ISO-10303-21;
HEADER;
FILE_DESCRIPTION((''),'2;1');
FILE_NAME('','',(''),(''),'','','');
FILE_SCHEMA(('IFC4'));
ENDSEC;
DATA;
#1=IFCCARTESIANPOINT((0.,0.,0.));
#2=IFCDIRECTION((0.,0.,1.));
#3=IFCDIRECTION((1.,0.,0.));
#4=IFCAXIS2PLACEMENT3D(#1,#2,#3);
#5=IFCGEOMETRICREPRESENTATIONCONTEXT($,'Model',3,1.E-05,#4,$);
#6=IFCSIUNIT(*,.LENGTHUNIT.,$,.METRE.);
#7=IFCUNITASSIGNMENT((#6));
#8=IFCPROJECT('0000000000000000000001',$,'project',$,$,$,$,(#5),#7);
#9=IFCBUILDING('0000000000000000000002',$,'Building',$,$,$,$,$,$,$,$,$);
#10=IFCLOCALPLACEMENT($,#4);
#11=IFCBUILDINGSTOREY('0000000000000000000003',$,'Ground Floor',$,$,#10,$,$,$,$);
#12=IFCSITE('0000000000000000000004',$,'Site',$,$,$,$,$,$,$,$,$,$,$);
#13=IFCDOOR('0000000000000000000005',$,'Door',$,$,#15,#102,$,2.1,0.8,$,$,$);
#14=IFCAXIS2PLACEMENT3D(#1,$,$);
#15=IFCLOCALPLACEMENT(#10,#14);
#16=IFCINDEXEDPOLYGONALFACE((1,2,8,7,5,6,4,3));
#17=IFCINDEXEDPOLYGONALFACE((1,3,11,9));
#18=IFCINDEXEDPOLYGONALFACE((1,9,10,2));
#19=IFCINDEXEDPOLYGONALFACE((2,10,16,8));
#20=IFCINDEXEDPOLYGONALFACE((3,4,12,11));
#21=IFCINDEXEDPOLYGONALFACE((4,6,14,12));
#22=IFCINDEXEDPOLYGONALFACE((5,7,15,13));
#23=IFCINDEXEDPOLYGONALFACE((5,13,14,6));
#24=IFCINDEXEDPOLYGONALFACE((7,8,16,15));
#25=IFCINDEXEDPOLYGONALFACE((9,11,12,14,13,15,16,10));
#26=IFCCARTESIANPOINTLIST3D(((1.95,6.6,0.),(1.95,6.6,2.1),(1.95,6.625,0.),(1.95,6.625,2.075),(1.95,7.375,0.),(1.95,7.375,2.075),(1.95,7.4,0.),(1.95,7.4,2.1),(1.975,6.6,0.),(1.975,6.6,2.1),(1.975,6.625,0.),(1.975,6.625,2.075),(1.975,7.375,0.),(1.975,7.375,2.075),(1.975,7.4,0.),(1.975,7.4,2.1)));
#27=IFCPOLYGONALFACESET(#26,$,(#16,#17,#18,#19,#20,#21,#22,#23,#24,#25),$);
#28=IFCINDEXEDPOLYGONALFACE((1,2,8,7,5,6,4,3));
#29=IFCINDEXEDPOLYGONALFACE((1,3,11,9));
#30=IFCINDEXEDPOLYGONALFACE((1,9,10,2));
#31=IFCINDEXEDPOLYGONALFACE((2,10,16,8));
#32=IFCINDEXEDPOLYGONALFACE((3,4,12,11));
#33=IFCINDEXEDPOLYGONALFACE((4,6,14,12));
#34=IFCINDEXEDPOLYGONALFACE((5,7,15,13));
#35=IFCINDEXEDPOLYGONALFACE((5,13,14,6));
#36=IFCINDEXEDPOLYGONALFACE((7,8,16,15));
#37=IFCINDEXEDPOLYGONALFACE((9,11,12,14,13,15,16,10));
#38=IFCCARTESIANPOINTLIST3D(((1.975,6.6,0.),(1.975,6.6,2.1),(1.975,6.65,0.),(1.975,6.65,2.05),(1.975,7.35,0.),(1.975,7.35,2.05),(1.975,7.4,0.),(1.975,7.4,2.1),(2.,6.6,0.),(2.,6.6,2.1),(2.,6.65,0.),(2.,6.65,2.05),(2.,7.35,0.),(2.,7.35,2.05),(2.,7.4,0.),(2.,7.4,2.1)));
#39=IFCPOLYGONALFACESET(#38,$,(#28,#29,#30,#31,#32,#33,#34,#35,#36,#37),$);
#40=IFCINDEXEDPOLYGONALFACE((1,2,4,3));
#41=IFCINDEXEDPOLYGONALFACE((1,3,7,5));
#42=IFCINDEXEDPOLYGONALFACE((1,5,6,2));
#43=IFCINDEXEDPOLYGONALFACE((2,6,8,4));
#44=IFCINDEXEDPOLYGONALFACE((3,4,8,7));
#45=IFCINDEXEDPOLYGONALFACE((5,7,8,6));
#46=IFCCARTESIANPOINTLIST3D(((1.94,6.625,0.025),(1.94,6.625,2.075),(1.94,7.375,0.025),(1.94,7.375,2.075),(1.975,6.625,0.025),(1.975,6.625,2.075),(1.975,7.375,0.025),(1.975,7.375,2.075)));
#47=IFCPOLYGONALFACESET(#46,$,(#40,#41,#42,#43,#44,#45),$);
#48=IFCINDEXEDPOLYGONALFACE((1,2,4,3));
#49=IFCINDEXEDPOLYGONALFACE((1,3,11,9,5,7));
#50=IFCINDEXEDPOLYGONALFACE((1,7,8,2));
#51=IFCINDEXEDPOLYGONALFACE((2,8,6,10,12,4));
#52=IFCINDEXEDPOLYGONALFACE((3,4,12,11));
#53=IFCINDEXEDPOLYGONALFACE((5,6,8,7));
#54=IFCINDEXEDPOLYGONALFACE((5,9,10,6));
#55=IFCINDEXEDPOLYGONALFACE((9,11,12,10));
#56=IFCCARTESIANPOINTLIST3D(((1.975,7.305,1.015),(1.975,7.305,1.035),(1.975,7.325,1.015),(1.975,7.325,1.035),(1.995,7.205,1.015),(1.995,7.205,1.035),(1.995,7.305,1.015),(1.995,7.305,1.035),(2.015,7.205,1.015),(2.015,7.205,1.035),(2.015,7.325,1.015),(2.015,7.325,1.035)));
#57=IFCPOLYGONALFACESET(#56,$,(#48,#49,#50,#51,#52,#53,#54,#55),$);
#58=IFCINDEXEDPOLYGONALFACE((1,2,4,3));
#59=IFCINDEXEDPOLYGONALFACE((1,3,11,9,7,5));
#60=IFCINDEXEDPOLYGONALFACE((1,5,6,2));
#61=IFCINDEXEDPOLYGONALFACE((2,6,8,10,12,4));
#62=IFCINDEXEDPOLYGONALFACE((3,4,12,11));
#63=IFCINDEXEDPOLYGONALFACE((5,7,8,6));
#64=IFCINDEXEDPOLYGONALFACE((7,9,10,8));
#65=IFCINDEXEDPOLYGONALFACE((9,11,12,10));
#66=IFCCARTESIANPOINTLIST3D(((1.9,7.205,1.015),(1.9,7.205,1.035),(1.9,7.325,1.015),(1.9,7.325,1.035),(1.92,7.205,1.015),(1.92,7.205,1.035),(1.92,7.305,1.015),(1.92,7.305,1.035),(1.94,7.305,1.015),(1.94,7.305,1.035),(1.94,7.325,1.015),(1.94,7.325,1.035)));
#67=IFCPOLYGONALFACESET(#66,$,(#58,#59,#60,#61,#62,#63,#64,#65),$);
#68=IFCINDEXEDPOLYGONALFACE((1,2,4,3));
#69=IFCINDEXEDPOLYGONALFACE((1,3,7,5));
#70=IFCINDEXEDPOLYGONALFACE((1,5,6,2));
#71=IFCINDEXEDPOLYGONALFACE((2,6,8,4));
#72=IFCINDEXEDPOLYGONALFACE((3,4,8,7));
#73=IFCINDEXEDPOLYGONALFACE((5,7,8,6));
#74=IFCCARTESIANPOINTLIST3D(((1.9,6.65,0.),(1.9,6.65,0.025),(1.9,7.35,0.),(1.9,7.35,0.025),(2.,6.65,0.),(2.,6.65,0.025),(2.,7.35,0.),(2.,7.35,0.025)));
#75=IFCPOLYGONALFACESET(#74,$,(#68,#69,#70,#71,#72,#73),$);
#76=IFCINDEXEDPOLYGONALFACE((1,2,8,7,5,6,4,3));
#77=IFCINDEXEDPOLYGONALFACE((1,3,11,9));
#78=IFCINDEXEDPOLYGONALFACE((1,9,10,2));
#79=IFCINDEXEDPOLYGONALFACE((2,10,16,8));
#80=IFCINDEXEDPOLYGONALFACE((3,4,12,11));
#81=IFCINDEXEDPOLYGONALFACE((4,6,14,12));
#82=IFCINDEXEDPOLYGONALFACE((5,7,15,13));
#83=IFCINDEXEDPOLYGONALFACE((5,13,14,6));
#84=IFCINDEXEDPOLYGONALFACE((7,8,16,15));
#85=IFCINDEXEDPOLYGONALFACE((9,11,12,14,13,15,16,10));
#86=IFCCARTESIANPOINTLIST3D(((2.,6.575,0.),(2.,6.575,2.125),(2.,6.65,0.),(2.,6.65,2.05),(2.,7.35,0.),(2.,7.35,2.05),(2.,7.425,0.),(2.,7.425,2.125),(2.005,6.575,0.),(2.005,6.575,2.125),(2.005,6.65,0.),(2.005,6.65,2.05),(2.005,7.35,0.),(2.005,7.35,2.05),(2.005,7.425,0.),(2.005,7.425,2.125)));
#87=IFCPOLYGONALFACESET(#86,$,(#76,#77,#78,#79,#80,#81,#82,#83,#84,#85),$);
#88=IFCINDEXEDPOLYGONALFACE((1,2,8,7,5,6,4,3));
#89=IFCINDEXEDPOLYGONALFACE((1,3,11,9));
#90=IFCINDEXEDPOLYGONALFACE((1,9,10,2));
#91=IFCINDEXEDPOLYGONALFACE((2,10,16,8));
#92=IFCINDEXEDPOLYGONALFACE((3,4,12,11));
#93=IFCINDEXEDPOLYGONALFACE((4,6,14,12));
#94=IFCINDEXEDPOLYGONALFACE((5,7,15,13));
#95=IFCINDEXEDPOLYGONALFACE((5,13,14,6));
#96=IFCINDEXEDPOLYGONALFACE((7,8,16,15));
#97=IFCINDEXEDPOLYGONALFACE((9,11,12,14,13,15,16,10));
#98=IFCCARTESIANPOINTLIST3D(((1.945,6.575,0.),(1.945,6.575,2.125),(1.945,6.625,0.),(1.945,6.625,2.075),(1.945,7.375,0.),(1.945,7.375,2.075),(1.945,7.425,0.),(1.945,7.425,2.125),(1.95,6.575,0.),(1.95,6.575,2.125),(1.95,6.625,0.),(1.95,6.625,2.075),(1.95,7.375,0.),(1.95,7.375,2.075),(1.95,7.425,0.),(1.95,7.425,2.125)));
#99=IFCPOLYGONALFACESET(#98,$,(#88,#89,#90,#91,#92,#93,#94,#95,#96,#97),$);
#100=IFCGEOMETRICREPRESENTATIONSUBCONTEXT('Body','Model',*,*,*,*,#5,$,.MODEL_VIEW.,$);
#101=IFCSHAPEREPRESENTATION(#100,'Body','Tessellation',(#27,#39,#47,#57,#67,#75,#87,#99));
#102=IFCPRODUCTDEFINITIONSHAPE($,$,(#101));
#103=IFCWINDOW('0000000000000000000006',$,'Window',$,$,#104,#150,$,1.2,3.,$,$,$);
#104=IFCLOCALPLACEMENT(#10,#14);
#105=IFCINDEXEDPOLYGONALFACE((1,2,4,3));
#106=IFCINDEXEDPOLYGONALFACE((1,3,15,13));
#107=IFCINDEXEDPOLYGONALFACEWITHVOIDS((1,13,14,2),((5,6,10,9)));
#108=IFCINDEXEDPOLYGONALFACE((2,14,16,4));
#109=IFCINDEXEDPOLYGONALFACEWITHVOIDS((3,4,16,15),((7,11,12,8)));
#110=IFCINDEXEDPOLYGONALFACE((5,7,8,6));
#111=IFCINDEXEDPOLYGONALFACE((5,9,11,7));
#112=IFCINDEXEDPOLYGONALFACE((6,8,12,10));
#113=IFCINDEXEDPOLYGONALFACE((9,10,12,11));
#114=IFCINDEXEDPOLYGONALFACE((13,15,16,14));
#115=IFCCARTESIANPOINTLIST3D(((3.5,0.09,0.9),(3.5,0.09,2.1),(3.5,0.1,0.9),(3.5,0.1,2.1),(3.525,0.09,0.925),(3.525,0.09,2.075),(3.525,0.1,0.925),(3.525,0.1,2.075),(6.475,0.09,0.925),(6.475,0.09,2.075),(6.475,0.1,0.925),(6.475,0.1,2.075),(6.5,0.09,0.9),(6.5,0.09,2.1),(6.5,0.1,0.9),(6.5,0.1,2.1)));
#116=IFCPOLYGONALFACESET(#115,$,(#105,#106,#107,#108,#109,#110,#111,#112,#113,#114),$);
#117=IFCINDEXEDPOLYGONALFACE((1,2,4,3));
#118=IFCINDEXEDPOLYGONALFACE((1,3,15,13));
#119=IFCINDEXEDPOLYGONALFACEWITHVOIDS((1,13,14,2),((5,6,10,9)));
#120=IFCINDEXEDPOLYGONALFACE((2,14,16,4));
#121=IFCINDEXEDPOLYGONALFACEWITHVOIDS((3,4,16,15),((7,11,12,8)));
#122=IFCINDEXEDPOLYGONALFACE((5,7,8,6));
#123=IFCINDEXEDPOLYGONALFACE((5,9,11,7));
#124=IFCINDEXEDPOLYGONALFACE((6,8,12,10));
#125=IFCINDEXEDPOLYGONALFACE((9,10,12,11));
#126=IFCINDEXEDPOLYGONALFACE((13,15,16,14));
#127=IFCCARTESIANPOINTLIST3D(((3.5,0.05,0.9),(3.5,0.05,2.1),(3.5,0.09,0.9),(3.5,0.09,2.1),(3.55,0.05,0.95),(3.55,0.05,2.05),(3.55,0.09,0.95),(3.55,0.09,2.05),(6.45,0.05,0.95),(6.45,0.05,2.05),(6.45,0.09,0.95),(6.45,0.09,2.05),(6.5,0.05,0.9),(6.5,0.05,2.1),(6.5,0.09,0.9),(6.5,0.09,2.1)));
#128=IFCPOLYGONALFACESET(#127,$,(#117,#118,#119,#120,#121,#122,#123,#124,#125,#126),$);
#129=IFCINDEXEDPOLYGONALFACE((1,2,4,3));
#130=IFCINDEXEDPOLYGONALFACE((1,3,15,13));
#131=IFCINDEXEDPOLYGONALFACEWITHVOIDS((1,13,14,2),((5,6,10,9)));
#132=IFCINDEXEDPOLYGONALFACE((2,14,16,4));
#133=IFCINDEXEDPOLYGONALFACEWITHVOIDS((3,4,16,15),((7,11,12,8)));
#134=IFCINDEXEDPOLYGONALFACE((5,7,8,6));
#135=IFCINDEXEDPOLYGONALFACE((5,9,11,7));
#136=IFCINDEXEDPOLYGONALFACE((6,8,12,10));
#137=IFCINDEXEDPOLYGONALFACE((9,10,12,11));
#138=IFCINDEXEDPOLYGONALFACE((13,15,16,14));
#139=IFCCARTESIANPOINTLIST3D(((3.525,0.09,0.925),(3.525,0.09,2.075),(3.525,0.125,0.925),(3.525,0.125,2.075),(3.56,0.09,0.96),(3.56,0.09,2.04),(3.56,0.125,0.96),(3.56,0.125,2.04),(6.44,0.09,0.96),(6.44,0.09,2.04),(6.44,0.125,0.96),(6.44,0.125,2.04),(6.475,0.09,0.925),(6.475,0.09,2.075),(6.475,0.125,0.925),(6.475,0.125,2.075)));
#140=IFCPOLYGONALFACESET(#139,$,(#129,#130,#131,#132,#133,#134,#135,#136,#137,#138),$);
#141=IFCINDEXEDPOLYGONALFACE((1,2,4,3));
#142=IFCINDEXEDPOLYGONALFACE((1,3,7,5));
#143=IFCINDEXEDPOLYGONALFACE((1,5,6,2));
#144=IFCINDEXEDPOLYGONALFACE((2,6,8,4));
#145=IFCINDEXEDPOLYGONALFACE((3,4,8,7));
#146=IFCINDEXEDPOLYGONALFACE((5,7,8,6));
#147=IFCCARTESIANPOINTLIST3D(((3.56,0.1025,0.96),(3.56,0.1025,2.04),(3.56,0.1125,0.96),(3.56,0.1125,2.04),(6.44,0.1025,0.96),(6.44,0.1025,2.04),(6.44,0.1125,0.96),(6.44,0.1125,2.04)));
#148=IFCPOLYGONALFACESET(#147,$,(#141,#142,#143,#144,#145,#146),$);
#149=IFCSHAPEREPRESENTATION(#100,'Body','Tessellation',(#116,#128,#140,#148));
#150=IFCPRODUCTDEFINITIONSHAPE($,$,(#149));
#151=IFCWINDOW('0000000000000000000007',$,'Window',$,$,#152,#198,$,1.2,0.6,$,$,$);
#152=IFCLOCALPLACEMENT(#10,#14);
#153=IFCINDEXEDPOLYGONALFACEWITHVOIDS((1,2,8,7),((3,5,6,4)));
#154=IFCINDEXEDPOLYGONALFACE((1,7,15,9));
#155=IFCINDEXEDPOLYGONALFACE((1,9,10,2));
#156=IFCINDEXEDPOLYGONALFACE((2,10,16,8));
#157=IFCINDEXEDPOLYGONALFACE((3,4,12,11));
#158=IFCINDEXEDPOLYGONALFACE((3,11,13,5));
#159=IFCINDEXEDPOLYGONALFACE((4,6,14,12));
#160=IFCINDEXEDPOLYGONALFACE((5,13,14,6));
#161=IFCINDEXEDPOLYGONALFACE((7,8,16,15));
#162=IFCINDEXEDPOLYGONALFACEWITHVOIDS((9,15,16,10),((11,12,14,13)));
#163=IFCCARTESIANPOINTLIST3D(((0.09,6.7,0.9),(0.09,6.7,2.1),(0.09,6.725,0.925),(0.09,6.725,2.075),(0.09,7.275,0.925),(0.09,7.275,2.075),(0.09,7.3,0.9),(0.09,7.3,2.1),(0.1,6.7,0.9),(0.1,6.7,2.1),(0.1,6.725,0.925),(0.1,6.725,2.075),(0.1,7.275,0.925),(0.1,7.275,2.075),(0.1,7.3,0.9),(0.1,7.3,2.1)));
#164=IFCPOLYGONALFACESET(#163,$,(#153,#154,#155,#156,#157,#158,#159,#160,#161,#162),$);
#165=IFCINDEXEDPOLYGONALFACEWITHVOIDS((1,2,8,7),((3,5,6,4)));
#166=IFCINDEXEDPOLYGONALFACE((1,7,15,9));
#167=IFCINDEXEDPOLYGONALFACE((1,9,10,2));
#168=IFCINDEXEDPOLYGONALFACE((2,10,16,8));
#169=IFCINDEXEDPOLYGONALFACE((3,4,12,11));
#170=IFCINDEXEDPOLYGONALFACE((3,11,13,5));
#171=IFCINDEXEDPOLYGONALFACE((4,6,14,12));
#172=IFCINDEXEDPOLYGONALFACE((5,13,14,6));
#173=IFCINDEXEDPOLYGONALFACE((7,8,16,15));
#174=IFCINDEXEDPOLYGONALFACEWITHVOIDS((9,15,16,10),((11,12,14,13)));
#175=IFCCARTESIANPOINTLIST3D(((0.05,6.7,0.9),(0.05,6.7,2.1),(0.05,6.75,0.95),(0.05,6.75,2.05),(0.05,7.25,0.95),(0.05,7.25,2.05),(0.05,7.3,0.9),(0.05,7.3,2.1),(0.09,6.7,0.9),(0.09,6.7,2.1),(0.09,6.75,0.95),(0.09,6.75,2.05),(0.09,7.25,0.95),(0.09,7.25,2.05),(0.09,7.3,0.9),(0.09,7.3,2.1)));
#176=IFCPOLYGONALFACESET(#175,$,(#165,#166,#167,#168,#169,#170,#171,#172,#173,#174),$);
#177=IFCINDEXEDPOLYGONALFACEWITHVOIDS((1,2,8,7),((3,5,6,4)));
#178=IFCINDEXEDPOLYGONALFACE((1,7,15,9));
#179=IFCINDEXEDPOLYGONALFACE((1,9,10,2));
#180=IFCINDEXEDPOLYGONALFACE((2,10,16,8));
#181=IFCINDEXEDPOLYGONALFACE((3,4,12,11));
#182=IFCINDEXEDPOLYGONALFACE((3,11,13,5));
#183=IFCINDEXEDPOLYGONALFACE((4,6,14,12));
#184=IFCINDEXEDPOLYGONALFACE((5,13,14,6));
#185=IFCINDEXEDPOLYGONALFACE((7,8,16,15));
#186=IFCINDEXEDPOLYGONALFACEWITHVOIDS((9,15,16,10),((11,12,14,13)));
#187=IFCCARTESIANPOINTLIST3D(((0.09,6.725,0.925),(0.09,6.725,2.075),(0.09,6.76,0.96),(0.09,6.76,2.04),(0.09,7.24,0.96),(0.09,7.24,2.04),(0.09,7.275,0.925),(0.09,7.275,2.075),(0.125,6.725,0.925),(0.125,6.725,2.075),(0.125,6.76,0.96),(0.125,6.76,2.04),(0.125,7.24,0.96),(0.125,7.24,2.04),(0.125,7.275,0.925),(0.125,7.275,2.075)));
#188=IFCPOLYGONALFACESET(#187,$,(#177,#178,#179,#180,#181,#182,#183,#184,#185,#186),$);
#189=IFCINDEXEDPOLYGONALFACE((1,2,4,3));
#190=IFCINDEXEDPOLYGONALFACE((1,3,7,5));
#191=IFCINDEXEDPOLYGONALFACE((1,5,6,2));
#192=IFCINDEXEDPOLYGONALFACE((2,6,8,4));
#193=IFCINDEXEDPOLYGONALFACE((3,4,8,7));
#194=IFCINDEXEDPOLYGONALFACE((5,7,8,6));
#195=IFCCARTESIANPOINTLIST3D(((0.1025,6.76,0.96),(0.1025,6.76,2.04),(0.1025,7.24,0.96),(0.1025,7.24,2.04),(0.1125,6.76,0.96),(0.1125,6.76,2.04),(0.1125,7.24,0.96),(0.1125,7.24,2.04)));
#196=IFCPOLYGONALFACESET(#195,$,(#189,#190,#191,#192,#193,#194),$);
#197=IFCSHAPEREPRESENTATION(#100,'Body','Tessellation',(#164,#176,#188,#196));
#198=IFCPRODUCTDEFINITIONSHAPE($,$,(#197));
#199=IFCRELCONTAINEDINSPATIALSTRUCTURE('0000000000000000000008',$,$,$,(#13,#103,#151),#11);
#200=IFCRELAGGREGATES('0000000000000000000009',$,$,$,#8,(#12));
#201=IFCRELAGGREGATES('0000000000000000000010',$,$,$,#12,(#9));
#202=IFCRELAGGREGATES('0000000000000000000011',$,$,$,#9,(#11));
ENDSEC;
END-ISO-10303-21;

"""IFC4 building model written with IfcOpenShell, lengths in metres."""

from ifc_helpers import new_model, si_unit, frame, origin_with_axes, place, context, subcontext, project, spatial, line, indexed_curve, outline, extrude, element, save


model = new_model("IFC4")

# Units and contexts
model_context = context("Model", 3, precision=1e-05, world=origin_with_axes())
body_context = subcontext(model_context, "Body", "Model", "MODEL_VIEW")
ifc_project = project(units=[si_unit("LENGTHUNIT", "METRE")], contexts=[model_context])

# Site, building, storey
site = spatial("IfcSite", under=ifc_project, Name="Site")
building = spatial("IfcBuilding", under=site, Name="Building")
storey_placement = place(None, origin_with_axes())
storey = spatial("IfcBuildingStorey", under=building, at=storey_placement, Name="Ground Floor")

# Door
door_1_placement = place(storey_placement, frame((2.0, 6.6, 0.0), z_axis=(0.0, 0.0, 1.0), x_axis=(0.0, 1.0, 0.0)))
element("IfcDoor", 1, at=door_1_placement, inside=storey, Name="Door", OverallHeight=2.1, OverallWidth=0.8, context=body_context, shape_type="SweptSolid", body=[
    extrude(outline(indexed_curve([(0.0, 0.0), (0.0, 2.1), (0.8, 2.1), (0.8, 0.0), (0.775, 0.0), (0.775, 2.075), (0.025, 2.075), (0.025, 0.0)], segments=[line(1, 2, 3, 4, 5, 6, 7, 8, 1)])), frame((0.0, 0.025, 0.0), z_axis=(0.0, -1.0, 0.0), x_axis=(1.0, 0.0, 0.0)), (0.0, 0.0, -1.0), 0.025),
    extrude(outline(indexed_curve([(0.0, 0.0), (0.0, 2.1), (0.8, 2.1), (0.8, 0.0), (0.75, 0.0), (0.75, 2.05), (0.05, 2.05), (0.05, 0.0)], segments=[line(1, 2, 3, 4, 5, 6, 7, 8, 1)])), frame((0.0, 0.0, 0.0), z_axis=(0.0, -1.0, 0.0), x_axis=(1.0, 0.0, 0.0)), (0.0, 0.0, -1.0), 0.025),
    extrude(outline(indexed_curve([(0.0, 0.0), (0.75, 0.0), (0.75, 0.035), (0.0, 0.035)], segments=[line(1, 2, 3, 4, 1)])), frame((0.025, 0.025, 0.025), z_axis=(0.0, 0.0, 1.0), x_axis=(1.0, 0.0, 0.0)), (0.0, 0.0, 1.0), 2.05),
    extrude(outline(indexed_curve([(0.0, 0.0), (0.0, -0.04), (-0.12, -0.04), (-0.12, -0.02), (-0.02, -0.02), (-0.02, 0.0)], segments=[line(1, 2, 3, 4, 5, 6, 1)])), frame((0.725, 0.025, 1.015), z_axis=(0.0, 0.0, 1.0), x_axis=(1.0, 0.0, 0.0)), (0.0, 0.0, 1.0), 0.02),
    extrude(outline(indexed_curve([(0.0, 0.0), (0.0, 0.04), (-0.12, 0.04), (-0.12, 0.02), (-0.02, 0.02), (-0.02, 0.0)], segments=[line(1, 2, 3, 4, 5, 6, 1)])), frame((0.725, 0.06, 1.015), z_axis=(0.0, 0.0, 1.0), x_axis=(1.0, 0.0, 0.0)), (0.0, 0.0, 1.0), 0.02),
    extrude(outline(indexed_curve([(0.0, 0.0), (0.7, 0.0), (0.7, 0.1), (0.0, 0.1)], segments=[line(1, 2, 3, 4, 1)])), frame((0.05, 0.0, 0.0), z_axis=(0.0, 0.0, 1.0), x_axis=(1.0, 0.0, 0.0)), (0.0, 0.0, 1.0), 0.025),
    extrude(outline(indexed_curve([(0.0, 0.0), (0.0, 2.125), (0.85, 2.125), (0.85, 0.0), (0.775, 0.0), (0.775, 2.05), (0.075, 2.05), (0.075, 0.0)], segments=[line(1, 2, 3, 4, 5, 6, 7, 8, 1)])), frame((-0.025, -0.005, 0.0), z_axis=(0.0, -1.0, 0.0), x_axis=(1.0, 0.0, 0.0)), (0.0, 0.0, -1.0), 0.005),
    extrude(outline(indexed_curve([(0.0, 0.0), (0.0, 2.125), (0.85, 2.125), (0.85, 0.0), (0.8, 0.0), (0.8, 2.075), (0.05, 2.075), (0.05, 0.0)], segments=[line(1, 2, 3, 4, 5, 6, 7, 8, 1)])), frame((-0.025, 0.05, 0.0), z_axis=(0.0, -1.0, 0.0), x_axis=(1.0, 0.0, 0.0)), (0.0, 0.0, -1.0), 0.005),
])

# Windows
window_placement = place(storey_placement, frame((3.5, 0.0, 0.9), z_axis=(0.0, 0.0, 1.0), x_axis=(1.0, 0.0, 0.0)))
element("IfcWindow", 2, at=window_placement, inside=storey, Name="Window", OverallHeight=1.2, OverallWidth=3.0, context=body_context, shape_type="SweptSolid", body=[
    extrude(outline(indexed_curve([(0.0, 0.0), (3.0, 0.0), (3.0, 1.2), (0.0, 1.2)], segments=[line(1, 2, 3, 4, 1)]), holes=[indexed_curve([(0.025, 0.025), (2.975, 0.025), (2.975, 1.175), (0.025, 1.175)], segments=[line(1, 2, 3, 4, 1)])]), frame((0.0, 0.09, 0.0), z_axis=(0.0, -1.0, 0.0), x_axis=(1.0, 0.0, 0.0)), (0.0, 0.0, -1.0), 0.01),
    extrude(outline(indexed_curve([(0.0, 0.0), (3.0, 0.0), (3.0, 1.2), (0.0, 1.2)], segments=[line(1, 2, 3, 4, 1)]), holes=[indexed_curve([(0.05, 0.05), (2.95, 0.05), (2.95, 1.15), (0.05, 1.15)], segments=[line(1, 2, 3, 4, 1)])]), frame((0.0, 0.05, 0.0), z_axis=(0.0, -1.0, 0.0), x_axis=(1.0, 0.0, 0.0)), (0.0, 0.0, -1.0), 0.04),
    extrude(outline(indexed_curve([(0.0, 0.0), (2.95, 0.0), (2.95, 1.15), (0.0, 1.15)], segments=[line(1, 2, 3, 4, 1)]), holes=[indexed_curve([(0.035, 0.035), (2.915, 0.035), (2.915, 1.115), (0.035, 1.115)], segments=[line(1, 2, 3, 4, 1)])]), frame((0.025, 0.09, 0.025), z_axis=(0.0, -1.0, 0.0), x_axis=(1.0, 0.0, 0.0)), (0.0, 0.0, -1.0), 0.035),
    extrude(outline(indexed_curve([(0.035, 0.035), (2.915, 0.035), (2.915, 1.115), (0.035, 1.115)], segments=[line(1, 2, 3, 4, 1)])), frame((0.025, 0.1025, 0.025), z_axis=(0.0, -1.0, 0.0), x_axis=(1.0, 0.0, 0.0)), (0.0, 0.0, -1.0), 0.01),
])
for number, where, z_axis, x_axis, name in (
    (3, (0.0, 7.3, 0.9), (0.0, 0.0, 1.0), (0.0, -1.0, 0.0), "Window"),
):
    element("IfcWindow", number, at=place(storey_placement, frame(where, z_axis=z_axis, x_axis=x_axis)), inside=storey, Name=name, OverallHeight=1.2, OverallWidth=0.6, context=body_context, shape_type="SweptSolid", body=[
        extrude(outline(indexed_curve([(0.0, 0.0), (0.6, 0.0), (0.6, 1.2), (0.0, 1.2)], segments=[line(1, 2, 3, 4, 1)]), holes=[indexed_curve([(0.025, 0.025), (0.575, 0.025), (0.575, 1.175), (0.025, 1.175)], segments=[line(1, 2, 3, 4, 1)])]), frame((0.0, 0.09, 0.0), z_axis=(0.0, -1.0, 0.0), x_axis=(1.0, 0.0, 0.0)), (0.0, 0.0, -1.0), 0.01),
        extrude(outline(indexed_curve([(0.0, 0.0), (0.6, 0.0), (0.6, 1.2), (0.0, 1.2)], segments=[line(1, 2, 3, 4, 1)]), holes=[indexed_curve([(0.05, 0.05), (0.55, 0.05), (0.55, 1.15), (0.05, 1.15)], segments=[line(1, 2, 3, 4, 1)])]), frame((0.0, 0.05, 0.0), z_axis=(0.0, -1.0, 0.0), x_axis=(1.0, 0.0, 0.0)), (0.0, 0.0, -1.0), 0.04),
        extrude(outline(indexed_curve([(0.0, 0.0), (0.55, 0.0), (0.55, 1.15), (0.0, 1.15)], segments=[line(1, 2, 3, 4, 1)]), holes=[indexed_curve([(0.035, 0.035), (0.515, 0.035), (0.515, 1.115), (0.035, 1.115)], segments=[line(1, 2, 3, 4, 1)])]), frame((0.025, 0.09, 0.025), z_axis=(0.0, -1.0, 0.0), x_axis=(1.0, 0.0, 0.0)), (0.0, 0.0, -1.0), 0.035),
        extrude(outline(indexed_curve([(0.035, 0.035), (0.515, 0.035), (0.515, 1.115), (0.035, 1.115)], segments=[line(1, 2, 3, 4, 1)])), frame((0.025, 0.1025, 0.025), z_axis=(0.0, -1.0, 0.0), x_axis=(1.0, 0.0, 0.0)), (0.0, 0.0, -1.0), 0.01),
    ])

save(model, "model.ifc")
